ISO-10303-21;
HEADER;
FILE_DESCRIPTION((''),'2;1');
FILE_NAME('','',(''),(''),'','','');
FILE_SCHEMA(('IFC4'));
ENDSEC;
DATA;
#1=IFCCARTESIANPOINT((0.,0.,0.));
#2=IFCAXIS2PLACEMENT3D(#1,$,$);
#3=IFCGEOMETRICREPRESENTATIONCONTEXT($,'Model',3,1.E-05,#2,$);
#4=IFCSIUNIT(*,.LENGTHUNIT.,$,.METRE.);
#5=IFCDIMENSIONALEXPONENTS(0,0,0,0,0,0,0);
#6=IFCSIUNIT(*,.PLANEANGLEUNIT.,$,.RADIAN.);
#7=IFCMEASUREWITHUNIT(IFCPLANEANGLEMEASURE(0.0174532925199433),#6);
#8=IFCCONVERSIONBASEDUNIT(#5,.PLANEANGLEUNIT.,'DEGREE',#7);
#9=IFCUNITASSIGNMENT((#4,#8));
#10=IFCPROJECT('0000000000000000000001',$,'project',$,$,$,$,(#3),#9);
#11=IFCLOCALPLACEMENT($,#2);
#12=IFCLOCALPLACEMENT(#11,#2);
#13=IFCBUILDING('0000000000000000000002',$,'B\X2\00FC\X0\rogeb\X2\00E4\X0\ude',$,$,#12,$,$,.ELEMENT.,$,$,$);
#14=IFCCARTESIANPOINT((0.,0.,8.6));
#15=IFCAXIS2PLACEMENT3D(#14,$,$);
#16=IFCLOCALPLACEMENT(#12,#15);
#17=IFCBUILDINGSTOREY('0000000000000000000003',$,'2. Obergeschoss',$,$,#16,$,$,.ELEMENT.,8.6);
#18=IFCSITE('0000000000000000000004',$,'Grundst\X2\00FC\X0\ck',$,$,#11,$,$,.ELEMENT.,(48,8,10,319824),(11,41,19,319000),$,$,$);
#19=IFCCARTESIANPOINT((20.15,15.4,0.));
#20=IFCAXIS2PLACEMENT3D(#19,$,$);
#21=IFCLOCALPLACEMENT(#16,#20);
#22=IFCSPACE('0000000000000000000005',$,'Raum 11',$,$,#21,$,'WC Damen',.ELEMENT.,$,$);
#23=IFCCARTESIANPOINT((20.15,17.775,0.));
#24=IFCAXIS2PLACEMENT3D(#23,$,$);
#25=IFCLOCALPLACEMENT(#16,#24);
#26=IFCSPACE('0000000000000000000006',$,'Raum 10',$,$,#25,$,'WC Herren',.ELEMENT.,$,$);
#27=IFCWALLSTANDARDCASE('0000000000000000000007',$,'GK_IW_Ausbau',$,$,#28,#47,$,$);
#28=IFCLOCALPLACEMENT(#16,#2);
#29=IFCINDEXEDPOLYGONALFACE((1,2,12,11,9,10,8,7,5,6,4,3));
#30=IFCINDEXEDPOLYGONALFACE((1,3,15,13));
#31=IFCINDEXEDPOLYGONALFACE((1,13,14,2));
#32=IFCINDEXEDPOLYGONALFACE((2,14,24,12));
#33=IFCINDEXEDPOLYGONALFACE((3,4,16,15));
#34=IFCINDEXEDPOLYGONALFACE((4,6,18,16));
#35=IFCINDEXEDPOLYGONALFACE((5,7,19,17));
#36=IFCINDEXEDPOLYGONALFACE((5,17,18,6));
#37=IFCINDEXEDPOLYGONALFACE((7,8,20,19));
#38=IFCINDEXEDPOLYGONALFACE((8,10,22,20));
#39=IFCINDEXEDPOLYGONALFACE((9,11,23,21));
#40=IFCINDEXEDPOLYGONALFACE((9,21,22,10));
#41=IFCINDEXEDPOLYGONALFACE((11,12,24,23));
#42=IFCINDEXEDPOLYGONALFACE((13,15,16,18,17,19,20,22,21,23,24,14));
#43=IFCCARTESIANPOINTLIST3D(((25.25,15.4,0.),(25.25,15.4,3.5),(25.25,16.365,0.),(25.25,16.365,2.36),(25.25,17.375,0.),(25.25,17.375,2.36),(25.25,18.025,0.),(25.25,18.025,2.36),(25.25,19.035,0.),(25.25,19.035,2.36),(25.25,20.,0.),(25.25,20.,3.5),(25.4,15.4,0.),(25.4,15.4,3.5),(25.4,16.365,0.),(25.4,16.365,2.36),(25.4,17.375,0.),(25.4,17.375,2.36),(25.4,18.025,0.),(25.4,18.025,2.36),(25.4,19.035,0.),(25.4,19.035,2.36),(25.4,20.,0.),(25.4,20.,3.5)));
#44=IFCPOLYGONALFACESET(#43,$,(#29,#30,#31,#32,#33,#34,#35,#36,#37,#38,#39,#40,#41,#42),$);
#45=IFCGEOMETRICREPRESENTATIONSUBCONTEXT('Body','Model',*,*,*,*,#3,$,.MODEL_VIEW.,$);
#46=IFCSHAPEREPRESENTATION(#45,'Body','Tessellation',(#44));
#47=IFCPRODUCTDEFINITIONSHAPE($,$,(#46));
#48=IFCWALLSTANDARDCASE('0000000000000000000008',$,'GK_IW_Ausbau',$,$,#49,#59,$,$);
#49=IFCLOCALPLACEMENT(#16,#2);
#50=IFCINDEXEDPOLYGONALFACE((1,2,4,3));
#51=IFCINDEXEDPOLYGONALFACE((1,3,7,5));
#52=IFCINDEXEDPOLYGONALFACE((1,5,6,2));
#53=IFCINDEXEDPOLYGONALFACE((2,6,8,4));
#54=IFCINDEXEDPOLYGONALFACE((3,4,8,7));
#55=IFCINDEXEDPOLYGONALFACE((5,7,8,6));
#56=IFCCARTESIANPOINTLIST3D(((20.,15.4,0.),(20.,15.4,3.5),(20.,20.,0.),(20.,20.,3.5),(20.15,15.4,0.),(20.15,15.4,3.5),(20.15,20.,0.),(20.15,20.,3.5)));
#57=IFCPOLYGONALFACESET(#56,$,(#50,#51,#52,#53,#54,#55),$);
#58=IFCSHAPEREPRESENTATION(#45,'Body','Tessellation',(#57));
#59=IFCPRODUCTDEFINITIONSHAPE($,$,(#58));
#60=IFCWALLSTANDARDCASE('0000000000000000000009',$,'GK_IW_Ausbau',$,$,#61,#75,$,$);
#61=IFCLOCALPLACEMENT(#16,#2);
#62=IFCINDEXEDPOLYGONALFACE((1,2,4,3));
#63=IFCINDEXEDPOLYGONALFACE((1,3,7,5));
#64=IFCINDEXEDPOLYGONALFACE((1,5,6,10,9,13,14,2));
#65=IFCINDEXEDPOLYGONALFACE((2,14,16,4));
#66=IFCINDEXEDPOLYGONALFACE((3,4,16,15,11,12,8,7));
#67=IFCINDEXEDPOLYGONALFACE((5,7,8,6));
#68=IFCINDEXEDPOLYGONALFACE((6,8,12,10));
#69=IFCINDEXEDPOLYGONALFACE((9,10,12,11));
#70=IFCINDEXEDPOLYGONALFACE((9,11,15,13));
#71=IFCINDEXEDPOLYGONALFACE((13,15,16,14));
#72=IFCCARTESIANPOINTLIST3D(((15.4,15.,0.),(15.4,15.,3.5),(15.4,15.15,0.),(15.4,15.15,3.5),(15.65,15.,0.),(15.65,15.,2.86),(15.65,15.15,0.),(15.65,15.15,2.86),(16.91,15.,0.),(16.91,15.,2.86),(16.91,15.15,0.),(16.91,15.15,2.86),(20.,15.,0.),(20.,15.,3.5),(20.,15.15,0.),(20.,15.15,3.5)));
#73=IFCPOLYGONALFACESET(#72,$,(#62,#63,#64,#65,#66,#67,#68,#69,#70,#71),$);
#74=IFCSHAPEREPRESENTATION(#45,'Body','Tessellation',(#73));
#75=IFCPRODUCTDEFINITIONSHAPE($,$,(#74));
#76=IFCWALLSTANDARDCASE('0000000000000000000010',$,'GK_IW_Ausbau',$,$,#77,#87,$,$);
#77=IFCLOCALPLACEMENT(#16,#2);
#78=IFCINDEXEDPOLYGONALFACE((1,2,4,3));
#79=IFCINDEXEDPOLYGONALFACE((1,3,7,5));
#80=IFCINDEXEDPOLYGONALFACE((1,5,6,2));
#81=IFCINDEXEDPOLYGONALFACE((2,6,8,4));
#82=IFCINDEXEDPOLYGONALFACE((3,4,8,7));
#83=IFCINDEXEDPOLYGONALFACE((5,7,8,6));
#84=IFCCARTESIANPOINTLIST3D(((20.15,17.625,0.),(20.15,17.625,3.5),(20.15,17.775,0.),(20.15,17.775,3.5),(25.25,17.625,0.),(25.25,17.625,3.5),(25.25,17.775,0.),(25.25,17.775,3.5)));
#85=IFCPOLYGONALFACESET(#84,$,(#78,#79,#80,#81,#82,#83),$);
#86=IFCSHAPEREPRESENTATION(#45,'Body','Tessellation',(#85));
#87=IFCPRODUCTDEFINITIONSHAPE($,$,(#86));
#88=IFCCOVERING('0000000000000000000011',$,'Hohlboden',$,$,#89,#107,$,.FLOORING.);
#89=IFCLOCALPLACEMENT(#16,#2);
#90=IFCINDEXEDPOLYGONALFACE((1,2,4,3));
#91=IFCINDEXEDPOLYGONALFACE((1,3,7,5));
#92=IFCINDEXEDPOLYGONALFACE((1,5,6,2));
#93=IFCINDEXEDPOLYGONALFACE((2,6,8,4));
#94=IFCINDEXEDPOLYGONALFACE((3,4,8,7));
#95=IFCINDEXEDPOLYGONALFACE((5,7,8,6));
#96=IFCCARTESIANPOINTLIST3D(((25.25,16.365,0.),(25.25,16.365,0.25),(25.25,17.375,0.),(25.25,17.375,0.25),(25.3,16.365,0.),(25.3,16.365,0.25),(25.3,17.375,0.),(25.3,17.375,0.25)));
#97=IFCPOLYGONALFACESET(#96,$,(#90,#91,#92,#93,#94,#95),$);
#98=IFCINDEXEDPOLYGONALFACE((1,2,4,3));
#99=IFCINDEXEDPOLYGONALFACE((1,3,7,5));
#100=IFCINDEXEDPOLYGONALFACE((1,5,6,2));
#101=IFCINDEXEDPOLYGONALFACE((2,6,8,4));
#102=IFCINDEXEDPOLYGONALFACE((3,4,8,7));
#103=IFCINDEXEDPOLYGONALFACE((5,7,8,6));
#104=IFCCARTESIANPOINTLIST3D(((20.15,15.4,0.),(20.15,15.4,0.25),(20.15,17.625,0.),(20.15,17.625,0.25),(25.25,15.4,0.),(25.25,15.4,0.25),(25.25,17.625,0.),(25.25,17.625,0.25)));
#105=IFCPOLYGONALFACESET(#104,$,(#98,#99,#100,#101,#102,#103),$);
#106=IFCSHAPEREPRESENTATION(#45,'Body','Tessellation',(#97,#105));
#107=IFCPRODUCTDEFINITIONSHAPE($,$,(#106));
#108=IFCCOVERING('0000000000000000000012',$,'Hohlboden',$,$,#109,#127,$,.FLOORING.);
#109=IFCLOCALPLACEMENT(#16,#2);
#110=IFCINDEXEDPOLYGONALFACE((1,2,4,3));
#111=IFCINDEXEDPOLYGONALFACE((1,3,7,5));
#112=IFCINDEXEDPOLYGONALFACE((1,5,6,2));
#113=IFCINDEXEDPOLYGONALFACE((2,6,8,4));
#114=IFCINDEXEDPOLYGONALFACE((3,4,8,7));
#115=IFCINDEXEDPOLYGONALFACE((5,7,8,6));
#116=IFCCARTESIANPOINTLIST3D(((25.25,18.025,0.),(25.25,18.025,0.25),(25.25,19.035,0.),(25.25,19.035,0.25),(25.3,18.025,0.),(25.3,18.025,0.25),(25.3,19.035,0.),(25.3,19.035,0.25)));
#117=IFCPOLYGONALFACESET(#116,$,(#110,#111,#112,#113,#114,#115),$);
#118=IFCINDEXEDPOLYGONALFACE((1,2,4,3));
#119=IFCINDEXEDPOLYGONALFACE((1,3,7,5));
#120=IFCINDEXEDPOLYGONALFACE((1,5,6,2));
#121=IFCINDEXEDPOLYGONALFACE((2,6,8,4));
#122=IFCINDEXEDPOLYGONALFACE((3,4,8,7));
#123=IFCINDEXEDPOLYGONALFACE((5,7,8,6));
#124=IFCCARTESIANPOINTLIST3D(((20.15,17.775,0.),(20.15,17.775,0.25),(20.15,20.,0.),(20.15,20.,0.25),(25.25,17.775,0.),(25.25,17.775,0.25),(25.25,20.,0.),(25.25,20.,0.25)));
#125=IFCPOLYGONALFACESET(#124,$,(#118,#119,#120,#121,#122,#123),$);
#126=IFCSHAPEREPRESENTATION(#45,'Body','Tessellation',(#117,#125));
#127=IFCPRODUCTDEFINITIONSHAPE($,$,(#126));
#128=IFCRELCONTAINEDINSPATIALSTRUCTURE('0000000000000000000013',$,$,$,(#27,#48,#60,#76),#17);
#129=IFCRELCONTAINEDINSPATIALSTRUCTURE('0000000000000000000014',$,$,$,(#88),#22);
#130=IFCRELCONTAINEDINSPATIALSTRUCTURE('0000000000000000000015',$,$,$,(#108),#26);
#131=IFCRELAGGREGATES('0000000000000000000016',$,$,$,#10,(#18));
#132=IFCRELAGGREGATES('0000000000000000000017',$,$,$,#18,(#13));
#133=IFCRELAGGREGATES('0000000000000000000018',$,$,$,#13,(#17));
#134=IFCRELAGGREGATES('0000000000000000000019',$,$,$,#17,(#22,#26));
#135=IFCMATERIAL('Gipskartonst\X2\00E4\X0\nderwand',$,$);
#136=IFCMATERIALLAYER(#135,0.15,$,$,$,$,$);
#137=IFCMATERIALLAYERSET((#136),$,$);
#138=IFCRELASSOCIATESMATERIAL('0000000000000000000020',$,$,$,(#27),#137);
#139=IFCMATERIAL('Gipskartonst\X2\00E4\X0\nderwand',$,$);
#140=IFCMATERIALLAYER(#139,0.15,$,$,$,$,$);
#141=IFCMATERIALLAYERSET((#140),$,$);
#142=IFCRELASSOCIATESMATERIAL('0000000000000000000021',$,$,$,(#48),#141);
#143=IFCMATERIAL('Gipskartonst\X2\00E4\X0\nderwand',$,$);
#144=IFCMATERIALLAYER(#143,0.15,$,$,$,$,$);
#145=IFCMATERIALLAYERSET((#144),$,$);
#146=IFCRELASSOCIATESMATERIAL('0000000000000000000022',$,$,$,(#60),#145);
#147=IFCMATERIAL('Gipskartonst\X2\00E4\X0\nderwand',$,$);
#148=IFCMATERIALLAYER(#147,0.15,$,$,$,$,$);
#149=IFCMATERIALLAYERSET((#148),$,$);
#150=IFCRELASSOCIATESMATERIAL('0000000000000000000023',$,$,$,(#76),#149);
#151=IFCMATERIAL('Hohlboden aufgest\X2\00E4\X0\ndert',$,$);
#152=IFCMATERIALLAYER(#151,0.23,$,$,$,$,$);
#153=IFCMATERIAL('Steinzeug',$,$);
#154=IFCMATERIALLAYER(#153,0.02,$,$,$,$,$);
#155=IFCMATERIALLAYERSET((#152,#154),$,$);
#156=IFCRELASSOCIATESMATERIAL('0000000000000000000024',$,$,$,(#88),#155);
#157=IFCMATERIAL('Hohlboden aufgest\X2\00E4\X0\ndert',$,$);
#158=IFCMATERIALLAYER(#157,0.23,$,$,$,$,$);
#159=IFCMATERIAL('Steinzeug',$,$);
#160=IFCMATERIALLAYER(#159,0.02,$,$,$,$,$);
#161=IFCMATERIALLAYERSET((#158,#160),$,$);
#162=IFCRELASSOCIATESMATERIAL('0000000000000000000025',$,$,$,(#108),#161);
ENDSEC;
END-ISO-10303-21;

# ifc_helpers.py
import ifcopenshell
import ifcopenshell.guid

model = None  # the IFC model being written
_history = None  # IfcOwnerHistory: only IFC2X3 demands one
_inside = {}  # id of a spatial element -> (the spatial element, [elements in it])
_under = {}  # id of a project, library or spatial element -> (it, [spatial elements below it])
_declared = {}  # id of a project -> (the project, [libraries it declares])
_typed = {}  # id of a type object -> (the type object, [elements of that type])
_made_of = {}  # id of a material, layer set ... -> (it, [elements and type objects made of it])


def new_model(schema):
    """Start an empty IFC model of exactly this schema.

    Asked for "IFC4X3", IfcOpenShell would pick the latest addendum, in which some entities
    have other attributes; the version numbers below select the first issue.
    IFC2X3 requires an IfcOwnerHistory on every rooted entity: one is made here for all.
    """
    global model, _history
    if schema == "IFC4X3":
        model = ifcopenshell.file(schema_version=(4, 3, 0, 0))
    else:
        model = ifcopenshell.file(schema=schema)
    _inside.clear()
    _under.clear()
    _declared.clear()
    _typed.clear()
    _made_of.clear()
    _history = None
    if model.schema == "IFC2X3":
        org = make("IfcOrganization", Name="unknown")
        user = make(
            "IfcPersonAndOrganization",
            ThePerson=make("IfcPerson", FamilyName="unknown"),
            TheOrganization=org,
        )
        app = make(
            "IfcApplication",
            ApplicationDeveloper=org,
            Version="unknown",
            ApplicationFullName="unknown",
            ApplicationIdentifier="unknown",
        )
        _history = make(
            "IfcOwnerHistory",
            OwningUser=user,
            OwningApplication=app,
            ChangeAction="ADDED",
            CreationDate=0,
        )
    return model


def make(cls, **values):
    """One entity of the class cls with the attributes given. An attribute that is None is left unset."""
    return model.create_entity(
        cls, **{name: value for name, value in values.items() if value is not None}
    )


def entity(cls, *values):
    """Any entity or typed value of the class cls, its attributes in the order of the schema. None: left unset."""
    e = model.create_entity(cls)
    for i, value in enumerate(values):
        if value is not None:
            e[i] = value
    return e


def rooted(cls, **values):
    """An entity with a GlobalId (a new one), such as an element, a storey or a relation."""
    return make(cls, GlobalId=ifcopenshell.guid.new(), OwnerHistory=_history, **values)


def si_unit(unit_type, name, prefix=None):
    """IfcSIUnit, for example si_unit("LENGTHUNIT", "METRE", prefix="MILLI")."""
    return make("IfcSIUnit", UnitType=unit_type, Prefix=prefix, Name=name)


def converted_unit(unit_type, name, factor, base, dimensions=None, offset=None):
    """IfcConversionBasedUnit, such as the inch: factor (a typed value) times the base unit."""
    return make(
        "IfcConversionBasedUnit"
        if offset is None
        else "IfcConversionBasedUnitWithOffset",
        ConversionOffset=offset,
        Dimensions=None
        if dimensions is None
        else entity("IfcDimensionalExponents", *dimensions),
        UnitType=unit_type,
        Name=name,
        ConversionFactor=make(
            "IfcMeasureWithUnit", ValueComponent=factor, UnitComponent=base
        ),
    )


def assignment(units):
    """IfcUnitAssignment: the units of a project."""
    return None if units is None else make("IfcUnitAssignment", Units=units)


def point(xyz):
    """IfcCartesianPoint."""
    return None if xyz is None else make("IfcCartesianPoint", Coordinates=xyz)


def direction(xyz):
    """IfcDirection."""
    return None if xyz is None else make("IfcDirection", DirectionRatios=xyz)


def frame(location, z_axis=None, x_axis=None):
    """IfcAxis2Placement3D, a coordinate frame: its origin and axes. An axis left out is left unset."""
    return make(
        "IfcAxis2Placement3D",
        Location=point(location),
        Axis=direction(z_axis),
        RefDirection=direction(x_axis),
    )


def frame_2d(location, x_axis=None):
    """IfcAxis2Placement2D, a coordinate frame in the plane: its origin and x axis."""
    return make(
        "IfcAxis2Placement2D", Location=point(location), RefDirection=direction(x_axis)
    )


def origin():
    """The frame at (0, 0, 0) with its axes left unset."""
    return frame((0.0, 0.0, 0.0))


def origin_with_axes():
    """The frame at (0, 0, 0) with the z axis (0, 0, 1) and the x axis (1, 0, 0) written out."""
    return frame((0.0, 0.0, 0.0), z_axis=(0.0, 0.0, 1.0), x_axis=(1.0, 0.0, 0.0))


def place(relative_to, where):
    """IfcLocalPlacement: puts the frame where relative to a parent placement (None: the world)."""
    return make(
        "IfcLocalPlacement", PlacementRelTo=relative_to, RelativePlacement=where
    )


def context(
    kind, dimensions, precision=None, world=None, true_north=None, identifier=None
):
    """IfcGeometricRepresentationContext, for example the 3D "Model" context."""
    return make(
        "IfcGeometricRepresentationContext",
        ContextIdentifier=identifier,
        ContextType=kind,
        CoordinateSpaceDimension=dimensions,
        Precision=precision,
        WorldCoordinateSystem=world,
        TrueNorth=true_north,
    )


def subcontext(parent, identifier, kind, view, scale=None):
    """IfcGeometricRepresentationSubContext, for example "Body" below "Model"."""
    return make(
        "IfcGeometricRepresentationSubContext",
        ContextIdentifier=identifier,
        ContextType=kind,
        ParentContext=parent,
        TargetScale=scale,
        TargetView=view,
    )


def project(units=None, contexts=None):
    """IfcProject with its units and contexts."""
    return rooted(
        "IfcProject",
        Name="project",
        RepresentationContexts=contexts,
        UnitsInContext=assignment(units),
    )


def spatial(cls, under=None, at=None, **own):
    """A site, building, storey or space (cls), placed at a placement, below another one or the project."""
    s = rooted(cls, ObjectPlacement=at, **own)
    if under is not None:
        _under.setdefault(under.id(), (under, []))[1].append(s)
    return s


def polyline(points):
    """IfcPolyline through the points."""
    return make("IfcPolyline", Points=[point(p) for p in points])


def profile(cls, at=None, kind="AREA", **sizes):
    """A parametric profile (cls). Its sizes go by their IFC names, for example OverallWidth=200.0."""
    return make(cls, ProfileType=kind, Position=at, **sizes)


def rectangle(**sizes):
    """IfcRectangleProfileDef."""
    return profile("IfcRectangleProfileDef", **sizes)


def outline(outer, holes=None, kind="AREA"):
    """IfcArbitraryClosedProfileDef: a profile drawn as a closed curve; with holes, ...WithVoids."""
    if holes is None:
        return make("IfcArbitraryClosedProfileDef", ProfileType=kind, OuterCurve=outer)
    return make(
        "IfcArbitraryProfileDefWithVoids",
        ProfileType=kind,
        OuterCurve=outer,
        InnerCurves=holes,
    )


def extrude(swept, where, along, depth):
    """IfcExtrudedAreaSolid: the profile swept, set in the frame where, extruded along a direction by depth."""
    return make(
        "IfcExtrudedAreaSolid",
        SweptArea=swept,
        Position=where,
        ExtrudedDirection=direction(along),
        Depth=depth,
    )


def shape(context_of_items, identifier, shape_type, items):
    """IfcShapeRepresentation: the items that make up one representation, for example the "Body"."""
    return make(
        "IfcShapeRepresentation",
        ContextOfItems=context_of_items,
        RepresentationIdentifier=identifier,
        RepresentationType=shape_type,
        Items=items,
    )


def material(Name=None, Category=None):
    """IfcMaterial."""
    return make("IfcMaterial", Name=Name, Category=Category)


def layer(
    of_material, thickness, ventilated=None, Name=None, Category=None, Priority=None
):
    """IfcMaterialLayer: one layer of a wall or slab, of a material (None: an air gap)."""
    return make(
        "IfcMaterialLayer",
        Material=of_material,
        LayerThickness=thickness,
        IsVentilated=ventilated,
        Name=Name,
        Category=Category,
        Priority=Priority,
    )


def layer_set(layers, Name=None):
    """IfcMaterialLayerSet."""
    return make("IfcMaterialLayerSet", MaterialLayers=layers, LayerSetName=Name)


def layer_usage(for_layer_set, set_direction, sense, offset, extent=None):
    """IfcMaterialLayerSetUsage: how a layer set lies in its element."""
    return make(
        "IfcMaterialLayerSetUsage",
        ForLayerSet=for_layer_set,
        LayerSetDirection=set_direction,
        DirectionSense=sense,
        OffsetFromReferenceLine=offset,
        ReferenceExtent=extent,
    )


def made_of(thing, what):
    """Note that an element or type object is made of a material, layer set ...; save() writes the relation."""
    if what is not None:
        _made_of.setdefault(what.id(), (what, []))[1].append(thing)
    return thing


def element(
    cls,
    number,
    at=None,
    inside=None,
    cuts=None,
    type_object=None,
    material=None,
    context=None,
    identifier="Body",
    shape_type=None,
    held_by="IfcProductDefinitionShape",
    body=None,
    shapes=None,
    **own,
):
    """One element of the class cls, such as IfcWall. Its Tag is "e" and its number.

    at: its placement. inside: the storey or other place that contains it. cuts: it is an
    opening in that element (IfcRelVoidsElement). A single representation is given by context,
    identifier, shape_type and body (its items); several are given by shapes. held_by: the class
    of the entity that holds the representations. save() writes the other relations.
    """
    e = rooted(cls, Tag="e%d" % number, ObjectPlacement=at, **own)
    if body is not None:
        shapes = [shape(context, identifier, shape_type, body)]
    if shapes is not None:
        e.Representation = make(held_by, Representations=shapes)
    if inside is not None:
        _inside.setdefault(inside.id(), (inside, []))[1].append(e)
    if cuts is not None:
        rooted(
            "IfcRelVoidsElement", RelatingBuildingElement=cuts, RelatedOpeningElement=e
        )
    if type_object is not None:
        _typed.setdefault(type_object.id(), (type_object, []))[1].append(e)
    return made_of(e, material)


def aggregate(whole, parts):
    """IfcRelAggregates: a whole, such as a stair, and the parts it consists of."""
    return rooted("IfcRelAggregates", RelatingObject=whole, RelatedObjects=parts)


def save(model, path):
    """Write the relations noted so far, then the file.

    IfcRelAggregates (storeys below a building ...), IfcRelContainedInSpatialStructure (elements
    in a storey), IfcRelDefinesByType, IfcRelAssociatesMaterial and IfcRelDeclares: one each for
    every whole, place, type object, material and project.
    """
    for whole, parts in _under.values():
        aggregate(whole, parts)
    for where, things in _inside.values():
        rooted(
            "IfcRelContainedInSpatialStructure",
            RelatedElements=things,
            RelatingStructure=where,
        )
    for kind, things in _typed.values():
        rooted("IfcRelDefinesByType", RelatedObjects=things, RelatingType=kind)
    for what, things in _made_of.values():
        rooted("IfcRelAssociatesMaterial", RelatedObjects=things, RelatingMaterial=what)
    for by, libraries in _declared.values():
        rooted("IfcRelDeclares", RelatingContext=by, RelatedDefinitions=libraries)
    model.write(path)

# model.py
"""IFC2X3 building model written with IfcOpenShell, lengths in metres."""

from ifc_helpers import new_model, entity, si_unit, converted_unit, frame, frame_2d, origin, origin_with_axes, place, context, subcontext, project, spatial, polyline, rectangle, outline, extrude, material, layer, layer_set, layer_usage, element, save


model = new_model("IFC2X3")

# Units and contexts
model_context = context("Model", 3, precision=1e-05, world=origin())
body_context = subcontext(model_context, "Body", "Model", "MODEL_VIEW")
ifc_project = project(units=[si_unit("LENGTHUNIT", "METRE"), converted_unit("PLANEANGLEUNIT", "DEGREE", entity("IfcPlaneAngleMeasure", 0.0174532925199433), si_unit("PLANEANGLEUNIT", "RADIAN"), dimensions=[0, 0, 0, 0, 0, 0, 0])], contexts=[model_context])

# Site, building, storey
site_placement = place(None, origin())
site = spatial("IfcSite", under=ifc_project, at=site_placement, Name="Grundstück", CompositionType="ELEMENT", RefLatitude=(48, 8, 10, 319824), RefLongitude=(11, 41, 19, 319000))
building_placement = place(site_placement, origin())
building = spatial("IfcBuilding", under=site, at=building_placement, Name="Bürogebäude", CompositionType="ELEMENT")
storey_placement = place(building_placement, frame((0.0, 0.0, 8.6)))
storey = spatial("IfcBuildingStorey", under=building, at=storey_placement, Name="2. Obergeschoss", CompositionType="ELEMENT", Elevation=8.6)

# Wall, openings
ifc_material_1 = material(Name="Gipskartonständerwand")
ifc_layer_1 = layer(ifc_material_1, 0.15)
ifc_layer_set_1 = layer_set([ifc_layer_1])
ifc_layer_usage_1 = layer_usage(ifc_layer_set_1, "AXIS2", "POSITIVE", -0.15)
wall_1_placement = place(storey_placement, frame((25.25, 20.0, 0.0), z_axis=(0.0, 0.0, 1.0), x_axis=(0.0, -1.0, 0.0)))
wall_1 = element("IfcWallStandardCase", 1, at=wall_1_placement, inside=storey, material=ifc_layer_usage_1, Name="GK_IW_Ausbau", context=body_context, shape_type="SweptSolid", body=[
    extrude(rectangle(XDim=4.6, YDim=0.15, at=frame_2d((2.3, 0.075), x_axis=(1.0, 0.0))), origin_with_axes(), (0.0, 0.0, 1.0), 3.5),
])
opening_1_placement = place(wall_1_placement, frame((3.635, 0.15, 0.0), z_axis=(0.0, -1.0, 0.0), x_axis=(0.0, 0.0, 1.0)))
element("IfcOpeningElement", 2, at=opening_1_placement, cuts=wall_1, ObjectType="Opening", context=body_context, shape_type="SweptSolid", body=[
    extrude(outline(polyline([(0.0, 1.01), (2.36, 1.01), (2.36, 0.0), (0.0, 0.0), (0.0, 1.01)])), origin_with_axes(), (0.0, 0.0, 1.0), 0.15),
])
opening_2_placement = place(wall_1_placement, frame((1.975, 0.15, 0.0), z_axis=(0.0, -1.0, 0.0), x_axis=(0.0, 0.0, 1.0)))
element("IfcOpeningElement", 3, at=opening_2_placement, cuts=wall_1, ObjectType="Opening", context=body_context, shape_type="SweptSolid", body=[
    extrude(outline(polyline([(0.0, 1.01), (2.36, 1.01), (2.36, 0.0), (0.0, 0.0), (0.0, 1.01)])), origin_with_axes(), (0.0, 0.0, 1.0), 0.15),
])

# Wall
ifc_material_2 = material(Name="Gipskartonständerwand")
ifc_layer_2 = layer(ifc_material_2, 0.15)
ifc_layer_set_2 = layer_set([ifc_layer_2])
ifc_layer_usage_2 = layer_usage(ifc_layer_set_2, "AXIS2", "POSITIVE", -0.15)
wall_2_placement = place(storey_placement, frame((20.15, 15.4, 0.0), z_axis=(0.0, 0.0, 1.0), x_axis=(0.0, 1.0, 0.0)))
element("IfcWallStandardCase", 4, at=wall_2_placement, inside=storey, material=ifc_layer_usage_2, Name="GK_IW_Ausbau", context=body_context, shape_type="SweptSolid", body=[
    extrude(rectangle(XDim=4.6, YDim=0.15, at=frame_2d((2.3, 0.075), x_axis=(1.0, 0.0))), origin_with_axes(), (0.0, 0.0, 1.0), 3.5),
])

# Wall, opening
ifc_material_3 = material(Name="Gipskartonständerwand")
ifc_layer_3 = layer(ifc_material_3, 0.15)
ifc_layer_set_3 = layer_set([ifc_layer_3])
ifc_layer_usage_3 = layer_usage(ifc_layer_set_3, "AXIS2", "POSITIVE", -0.15)
wall_3_placement = place(storey_placement, frame((20.0, 15.15, 0.0), z_axis=(0.0, 0.0, 1.0), x_axis=(-1.0, 0.0, 0.0)))
wall_3 = element("IfcWallStandardCase", 5, at=wall_3_placement, inside=storey, material=ifc_layer_usage_3, Name="GK_IW_Ausbau", context=body_context, shape_type="SweptSolid", body=[
    extrude(rectangle(XDim=4.6, YDim=0.15, at=frame_2d((2.3, 0.075), x_axis=(1.0, 0.0))), origin_with_axes(), (0.0, 0.0, 1.0), 3.5),
])
opening_3_placement = place(wall_3_placement, frame((4.35, 0.15, 0.0), z_axis=(0.0, -1.0, 0.0), x_axis=(0.0, 0.0, 1.0)))
element("IfcOpeningElement", 6, at=opening_3_placement, cuts=wall_3, ObjectType="Opening", context=body_context, shape_type="SweptSolid", body=[
    extrude(outline(polyline([(0.0, 1.26), (2.86, 1.26), (2.86, 0.0), (0.0, 0.0), (0.0, 1.26)])), origin_with_axes(), (0.0, 0.0, 1.0), 0.15),
])

# Wall
ifc_material_4 = material(Name="Gipskartonständerwand")
ifc_layer_4 = layer(ifc_material_4, 0.15)
ifc_layer_set_4 = layer_set([ifc_layer_4])
ifc_layer_usage_4 = layer_usage(ifc_layer_set_4, "AXIS2", "POSITIVE", -0.075)
wall_4_placement = place(storey_placement, frame((20.15, 17.625, 0.0)))
element("IfcWallStandardCase", 7, at=wall_4_placement, inside=storey, material=ifc_layer_usage_4, Name="GK_IW_Ausbau", context=body_context, shape_type="SweptSolid", body=[
    extrude(rectangle(XDim=5.1, YDim=0.15, at=frame_2d((2.55, 0.075), x_axis=(1.0, 0.0))), origin_with_axes(), (0.0, 0.0, 1.0), 3.5),
])

# Shared definitions
space_1_placement = place(storey_placement, frame((20.15, 15.4, 0.0)))
space_1 = spatial("IfcSpace", under=storey, at=space_1_placement, Name="Raum 11", LongName="WC Damen", CompositionType="ELEMENT")

# Covering
ifc_material_5 = material(Name="Hohlboden aufgeständert")
ifc_layer_5 = layer(ifc_material_5, 0.23)
ifc_material_6 = material(Name="Steinzeug")
ifc_layer_6 = layer(ifc_material_6, 0.02)
ifc_layer_set_5 = layer_set([ifc_layer_5, ifc_layer_6])
ifc_layer_usage_5 = layer_usage(ifc_layer_set_5, "AXIS3", "POSITIVE", 0.0)
covering_1_placement = place(storey_placement, frame((20.15, 15.4, 0.0)))
element("IfcCovering", 8, at=covering_1_placement, inside=space_1, material=ifc_layer_usage_5, Name="Hohlboden", PredefinedType="FLOORING", context=body_context, shape_type="SweptSolid", body=[
    extrude(rectangle(XDim=0.05, YDim=1.01, at=frame_2d((0.025, 0.505), x_axis=(1.0, 0.0))), frame((5.1, 0.965, 0.0), z_axis=(0.0, 0.0, 1.0), x_axis=(1.0, 0.0, 0.0)), (0.0, 0.0, 1.0), 0.25),
    extrude(rectangle(XDim=2.225, YDim=5.1, at=frame_2d((2.55, -1.1125), x_axis=(0.0, -1.0))), frame((0.0, 2.225, 0.0), z_axis=(0.0, 0.0, 1.0), x_axis=(1.0, 0.0, 0.0)), (0.0, 0.0, 1.0), 0.25),
])

# Shared definitions
space_2_placement = place(storey_placement, frame((20.15, 17.775, 0.0)))
space_2 = spatial("IfcSpace", under=storey, at=space_2_placement, Name="Raum 10", LongName="WC Herren", CompositionType="ELEMENT")

# Covering
ifc_material_7 = material(Name="Hohlboden aufgeständert")
ifc_layer_7 = layer(ifc_material_7, 0.23)
ifc_material_8 = material(Name="Steinzeug")
ifc_layer_8 = layer(ifc_material_8, 0.02)
ifc_layer_set_6 = layer_set([ifc_layer_7, ifc_layer_8])
ifc_layer_usage_6 = layer_usage(ifc_layer_set_6, "AXIS3", "POSITIVE", 0.0)
covering_2_placement = place(storey_placement, frame((20.15, 17.775, 0.0)))
element("IfcCovering", 9, at=covering_2_placement, inside=space_2, material=ifc_layer_usage_6, Name="Hohlboden", PredefinedType="FLOORING", context=body_context, shape_type="SweptSolid", body=[
    extrude(rectangle(XDim=0.05, YDim=1.01, at=frame_2d((0.025, 0.505), x_axis=(1.0, 0.0))), frame((5.1, 0.25, 0.0), z_axis=(0.0, 0.0, 1.0), x_axis=(1.0, 0.0, 0.0)), (0.0, 0.0, 1.0), 0.25),
    extrude(rectangle(XDim=5.1, YDim=2.225, at=frame_2d((-2.55, -1.1125), x_axis=(-1.0, 0.0))), frame((5.1, 2.225, 0.0), z_axis=(0.0, 0.0, 1.0), x_axis=(1.0, 0.0, 0.0)), (0.0, 0.0, 1.0), 0.25),
])

save(model, "model.ifc")
